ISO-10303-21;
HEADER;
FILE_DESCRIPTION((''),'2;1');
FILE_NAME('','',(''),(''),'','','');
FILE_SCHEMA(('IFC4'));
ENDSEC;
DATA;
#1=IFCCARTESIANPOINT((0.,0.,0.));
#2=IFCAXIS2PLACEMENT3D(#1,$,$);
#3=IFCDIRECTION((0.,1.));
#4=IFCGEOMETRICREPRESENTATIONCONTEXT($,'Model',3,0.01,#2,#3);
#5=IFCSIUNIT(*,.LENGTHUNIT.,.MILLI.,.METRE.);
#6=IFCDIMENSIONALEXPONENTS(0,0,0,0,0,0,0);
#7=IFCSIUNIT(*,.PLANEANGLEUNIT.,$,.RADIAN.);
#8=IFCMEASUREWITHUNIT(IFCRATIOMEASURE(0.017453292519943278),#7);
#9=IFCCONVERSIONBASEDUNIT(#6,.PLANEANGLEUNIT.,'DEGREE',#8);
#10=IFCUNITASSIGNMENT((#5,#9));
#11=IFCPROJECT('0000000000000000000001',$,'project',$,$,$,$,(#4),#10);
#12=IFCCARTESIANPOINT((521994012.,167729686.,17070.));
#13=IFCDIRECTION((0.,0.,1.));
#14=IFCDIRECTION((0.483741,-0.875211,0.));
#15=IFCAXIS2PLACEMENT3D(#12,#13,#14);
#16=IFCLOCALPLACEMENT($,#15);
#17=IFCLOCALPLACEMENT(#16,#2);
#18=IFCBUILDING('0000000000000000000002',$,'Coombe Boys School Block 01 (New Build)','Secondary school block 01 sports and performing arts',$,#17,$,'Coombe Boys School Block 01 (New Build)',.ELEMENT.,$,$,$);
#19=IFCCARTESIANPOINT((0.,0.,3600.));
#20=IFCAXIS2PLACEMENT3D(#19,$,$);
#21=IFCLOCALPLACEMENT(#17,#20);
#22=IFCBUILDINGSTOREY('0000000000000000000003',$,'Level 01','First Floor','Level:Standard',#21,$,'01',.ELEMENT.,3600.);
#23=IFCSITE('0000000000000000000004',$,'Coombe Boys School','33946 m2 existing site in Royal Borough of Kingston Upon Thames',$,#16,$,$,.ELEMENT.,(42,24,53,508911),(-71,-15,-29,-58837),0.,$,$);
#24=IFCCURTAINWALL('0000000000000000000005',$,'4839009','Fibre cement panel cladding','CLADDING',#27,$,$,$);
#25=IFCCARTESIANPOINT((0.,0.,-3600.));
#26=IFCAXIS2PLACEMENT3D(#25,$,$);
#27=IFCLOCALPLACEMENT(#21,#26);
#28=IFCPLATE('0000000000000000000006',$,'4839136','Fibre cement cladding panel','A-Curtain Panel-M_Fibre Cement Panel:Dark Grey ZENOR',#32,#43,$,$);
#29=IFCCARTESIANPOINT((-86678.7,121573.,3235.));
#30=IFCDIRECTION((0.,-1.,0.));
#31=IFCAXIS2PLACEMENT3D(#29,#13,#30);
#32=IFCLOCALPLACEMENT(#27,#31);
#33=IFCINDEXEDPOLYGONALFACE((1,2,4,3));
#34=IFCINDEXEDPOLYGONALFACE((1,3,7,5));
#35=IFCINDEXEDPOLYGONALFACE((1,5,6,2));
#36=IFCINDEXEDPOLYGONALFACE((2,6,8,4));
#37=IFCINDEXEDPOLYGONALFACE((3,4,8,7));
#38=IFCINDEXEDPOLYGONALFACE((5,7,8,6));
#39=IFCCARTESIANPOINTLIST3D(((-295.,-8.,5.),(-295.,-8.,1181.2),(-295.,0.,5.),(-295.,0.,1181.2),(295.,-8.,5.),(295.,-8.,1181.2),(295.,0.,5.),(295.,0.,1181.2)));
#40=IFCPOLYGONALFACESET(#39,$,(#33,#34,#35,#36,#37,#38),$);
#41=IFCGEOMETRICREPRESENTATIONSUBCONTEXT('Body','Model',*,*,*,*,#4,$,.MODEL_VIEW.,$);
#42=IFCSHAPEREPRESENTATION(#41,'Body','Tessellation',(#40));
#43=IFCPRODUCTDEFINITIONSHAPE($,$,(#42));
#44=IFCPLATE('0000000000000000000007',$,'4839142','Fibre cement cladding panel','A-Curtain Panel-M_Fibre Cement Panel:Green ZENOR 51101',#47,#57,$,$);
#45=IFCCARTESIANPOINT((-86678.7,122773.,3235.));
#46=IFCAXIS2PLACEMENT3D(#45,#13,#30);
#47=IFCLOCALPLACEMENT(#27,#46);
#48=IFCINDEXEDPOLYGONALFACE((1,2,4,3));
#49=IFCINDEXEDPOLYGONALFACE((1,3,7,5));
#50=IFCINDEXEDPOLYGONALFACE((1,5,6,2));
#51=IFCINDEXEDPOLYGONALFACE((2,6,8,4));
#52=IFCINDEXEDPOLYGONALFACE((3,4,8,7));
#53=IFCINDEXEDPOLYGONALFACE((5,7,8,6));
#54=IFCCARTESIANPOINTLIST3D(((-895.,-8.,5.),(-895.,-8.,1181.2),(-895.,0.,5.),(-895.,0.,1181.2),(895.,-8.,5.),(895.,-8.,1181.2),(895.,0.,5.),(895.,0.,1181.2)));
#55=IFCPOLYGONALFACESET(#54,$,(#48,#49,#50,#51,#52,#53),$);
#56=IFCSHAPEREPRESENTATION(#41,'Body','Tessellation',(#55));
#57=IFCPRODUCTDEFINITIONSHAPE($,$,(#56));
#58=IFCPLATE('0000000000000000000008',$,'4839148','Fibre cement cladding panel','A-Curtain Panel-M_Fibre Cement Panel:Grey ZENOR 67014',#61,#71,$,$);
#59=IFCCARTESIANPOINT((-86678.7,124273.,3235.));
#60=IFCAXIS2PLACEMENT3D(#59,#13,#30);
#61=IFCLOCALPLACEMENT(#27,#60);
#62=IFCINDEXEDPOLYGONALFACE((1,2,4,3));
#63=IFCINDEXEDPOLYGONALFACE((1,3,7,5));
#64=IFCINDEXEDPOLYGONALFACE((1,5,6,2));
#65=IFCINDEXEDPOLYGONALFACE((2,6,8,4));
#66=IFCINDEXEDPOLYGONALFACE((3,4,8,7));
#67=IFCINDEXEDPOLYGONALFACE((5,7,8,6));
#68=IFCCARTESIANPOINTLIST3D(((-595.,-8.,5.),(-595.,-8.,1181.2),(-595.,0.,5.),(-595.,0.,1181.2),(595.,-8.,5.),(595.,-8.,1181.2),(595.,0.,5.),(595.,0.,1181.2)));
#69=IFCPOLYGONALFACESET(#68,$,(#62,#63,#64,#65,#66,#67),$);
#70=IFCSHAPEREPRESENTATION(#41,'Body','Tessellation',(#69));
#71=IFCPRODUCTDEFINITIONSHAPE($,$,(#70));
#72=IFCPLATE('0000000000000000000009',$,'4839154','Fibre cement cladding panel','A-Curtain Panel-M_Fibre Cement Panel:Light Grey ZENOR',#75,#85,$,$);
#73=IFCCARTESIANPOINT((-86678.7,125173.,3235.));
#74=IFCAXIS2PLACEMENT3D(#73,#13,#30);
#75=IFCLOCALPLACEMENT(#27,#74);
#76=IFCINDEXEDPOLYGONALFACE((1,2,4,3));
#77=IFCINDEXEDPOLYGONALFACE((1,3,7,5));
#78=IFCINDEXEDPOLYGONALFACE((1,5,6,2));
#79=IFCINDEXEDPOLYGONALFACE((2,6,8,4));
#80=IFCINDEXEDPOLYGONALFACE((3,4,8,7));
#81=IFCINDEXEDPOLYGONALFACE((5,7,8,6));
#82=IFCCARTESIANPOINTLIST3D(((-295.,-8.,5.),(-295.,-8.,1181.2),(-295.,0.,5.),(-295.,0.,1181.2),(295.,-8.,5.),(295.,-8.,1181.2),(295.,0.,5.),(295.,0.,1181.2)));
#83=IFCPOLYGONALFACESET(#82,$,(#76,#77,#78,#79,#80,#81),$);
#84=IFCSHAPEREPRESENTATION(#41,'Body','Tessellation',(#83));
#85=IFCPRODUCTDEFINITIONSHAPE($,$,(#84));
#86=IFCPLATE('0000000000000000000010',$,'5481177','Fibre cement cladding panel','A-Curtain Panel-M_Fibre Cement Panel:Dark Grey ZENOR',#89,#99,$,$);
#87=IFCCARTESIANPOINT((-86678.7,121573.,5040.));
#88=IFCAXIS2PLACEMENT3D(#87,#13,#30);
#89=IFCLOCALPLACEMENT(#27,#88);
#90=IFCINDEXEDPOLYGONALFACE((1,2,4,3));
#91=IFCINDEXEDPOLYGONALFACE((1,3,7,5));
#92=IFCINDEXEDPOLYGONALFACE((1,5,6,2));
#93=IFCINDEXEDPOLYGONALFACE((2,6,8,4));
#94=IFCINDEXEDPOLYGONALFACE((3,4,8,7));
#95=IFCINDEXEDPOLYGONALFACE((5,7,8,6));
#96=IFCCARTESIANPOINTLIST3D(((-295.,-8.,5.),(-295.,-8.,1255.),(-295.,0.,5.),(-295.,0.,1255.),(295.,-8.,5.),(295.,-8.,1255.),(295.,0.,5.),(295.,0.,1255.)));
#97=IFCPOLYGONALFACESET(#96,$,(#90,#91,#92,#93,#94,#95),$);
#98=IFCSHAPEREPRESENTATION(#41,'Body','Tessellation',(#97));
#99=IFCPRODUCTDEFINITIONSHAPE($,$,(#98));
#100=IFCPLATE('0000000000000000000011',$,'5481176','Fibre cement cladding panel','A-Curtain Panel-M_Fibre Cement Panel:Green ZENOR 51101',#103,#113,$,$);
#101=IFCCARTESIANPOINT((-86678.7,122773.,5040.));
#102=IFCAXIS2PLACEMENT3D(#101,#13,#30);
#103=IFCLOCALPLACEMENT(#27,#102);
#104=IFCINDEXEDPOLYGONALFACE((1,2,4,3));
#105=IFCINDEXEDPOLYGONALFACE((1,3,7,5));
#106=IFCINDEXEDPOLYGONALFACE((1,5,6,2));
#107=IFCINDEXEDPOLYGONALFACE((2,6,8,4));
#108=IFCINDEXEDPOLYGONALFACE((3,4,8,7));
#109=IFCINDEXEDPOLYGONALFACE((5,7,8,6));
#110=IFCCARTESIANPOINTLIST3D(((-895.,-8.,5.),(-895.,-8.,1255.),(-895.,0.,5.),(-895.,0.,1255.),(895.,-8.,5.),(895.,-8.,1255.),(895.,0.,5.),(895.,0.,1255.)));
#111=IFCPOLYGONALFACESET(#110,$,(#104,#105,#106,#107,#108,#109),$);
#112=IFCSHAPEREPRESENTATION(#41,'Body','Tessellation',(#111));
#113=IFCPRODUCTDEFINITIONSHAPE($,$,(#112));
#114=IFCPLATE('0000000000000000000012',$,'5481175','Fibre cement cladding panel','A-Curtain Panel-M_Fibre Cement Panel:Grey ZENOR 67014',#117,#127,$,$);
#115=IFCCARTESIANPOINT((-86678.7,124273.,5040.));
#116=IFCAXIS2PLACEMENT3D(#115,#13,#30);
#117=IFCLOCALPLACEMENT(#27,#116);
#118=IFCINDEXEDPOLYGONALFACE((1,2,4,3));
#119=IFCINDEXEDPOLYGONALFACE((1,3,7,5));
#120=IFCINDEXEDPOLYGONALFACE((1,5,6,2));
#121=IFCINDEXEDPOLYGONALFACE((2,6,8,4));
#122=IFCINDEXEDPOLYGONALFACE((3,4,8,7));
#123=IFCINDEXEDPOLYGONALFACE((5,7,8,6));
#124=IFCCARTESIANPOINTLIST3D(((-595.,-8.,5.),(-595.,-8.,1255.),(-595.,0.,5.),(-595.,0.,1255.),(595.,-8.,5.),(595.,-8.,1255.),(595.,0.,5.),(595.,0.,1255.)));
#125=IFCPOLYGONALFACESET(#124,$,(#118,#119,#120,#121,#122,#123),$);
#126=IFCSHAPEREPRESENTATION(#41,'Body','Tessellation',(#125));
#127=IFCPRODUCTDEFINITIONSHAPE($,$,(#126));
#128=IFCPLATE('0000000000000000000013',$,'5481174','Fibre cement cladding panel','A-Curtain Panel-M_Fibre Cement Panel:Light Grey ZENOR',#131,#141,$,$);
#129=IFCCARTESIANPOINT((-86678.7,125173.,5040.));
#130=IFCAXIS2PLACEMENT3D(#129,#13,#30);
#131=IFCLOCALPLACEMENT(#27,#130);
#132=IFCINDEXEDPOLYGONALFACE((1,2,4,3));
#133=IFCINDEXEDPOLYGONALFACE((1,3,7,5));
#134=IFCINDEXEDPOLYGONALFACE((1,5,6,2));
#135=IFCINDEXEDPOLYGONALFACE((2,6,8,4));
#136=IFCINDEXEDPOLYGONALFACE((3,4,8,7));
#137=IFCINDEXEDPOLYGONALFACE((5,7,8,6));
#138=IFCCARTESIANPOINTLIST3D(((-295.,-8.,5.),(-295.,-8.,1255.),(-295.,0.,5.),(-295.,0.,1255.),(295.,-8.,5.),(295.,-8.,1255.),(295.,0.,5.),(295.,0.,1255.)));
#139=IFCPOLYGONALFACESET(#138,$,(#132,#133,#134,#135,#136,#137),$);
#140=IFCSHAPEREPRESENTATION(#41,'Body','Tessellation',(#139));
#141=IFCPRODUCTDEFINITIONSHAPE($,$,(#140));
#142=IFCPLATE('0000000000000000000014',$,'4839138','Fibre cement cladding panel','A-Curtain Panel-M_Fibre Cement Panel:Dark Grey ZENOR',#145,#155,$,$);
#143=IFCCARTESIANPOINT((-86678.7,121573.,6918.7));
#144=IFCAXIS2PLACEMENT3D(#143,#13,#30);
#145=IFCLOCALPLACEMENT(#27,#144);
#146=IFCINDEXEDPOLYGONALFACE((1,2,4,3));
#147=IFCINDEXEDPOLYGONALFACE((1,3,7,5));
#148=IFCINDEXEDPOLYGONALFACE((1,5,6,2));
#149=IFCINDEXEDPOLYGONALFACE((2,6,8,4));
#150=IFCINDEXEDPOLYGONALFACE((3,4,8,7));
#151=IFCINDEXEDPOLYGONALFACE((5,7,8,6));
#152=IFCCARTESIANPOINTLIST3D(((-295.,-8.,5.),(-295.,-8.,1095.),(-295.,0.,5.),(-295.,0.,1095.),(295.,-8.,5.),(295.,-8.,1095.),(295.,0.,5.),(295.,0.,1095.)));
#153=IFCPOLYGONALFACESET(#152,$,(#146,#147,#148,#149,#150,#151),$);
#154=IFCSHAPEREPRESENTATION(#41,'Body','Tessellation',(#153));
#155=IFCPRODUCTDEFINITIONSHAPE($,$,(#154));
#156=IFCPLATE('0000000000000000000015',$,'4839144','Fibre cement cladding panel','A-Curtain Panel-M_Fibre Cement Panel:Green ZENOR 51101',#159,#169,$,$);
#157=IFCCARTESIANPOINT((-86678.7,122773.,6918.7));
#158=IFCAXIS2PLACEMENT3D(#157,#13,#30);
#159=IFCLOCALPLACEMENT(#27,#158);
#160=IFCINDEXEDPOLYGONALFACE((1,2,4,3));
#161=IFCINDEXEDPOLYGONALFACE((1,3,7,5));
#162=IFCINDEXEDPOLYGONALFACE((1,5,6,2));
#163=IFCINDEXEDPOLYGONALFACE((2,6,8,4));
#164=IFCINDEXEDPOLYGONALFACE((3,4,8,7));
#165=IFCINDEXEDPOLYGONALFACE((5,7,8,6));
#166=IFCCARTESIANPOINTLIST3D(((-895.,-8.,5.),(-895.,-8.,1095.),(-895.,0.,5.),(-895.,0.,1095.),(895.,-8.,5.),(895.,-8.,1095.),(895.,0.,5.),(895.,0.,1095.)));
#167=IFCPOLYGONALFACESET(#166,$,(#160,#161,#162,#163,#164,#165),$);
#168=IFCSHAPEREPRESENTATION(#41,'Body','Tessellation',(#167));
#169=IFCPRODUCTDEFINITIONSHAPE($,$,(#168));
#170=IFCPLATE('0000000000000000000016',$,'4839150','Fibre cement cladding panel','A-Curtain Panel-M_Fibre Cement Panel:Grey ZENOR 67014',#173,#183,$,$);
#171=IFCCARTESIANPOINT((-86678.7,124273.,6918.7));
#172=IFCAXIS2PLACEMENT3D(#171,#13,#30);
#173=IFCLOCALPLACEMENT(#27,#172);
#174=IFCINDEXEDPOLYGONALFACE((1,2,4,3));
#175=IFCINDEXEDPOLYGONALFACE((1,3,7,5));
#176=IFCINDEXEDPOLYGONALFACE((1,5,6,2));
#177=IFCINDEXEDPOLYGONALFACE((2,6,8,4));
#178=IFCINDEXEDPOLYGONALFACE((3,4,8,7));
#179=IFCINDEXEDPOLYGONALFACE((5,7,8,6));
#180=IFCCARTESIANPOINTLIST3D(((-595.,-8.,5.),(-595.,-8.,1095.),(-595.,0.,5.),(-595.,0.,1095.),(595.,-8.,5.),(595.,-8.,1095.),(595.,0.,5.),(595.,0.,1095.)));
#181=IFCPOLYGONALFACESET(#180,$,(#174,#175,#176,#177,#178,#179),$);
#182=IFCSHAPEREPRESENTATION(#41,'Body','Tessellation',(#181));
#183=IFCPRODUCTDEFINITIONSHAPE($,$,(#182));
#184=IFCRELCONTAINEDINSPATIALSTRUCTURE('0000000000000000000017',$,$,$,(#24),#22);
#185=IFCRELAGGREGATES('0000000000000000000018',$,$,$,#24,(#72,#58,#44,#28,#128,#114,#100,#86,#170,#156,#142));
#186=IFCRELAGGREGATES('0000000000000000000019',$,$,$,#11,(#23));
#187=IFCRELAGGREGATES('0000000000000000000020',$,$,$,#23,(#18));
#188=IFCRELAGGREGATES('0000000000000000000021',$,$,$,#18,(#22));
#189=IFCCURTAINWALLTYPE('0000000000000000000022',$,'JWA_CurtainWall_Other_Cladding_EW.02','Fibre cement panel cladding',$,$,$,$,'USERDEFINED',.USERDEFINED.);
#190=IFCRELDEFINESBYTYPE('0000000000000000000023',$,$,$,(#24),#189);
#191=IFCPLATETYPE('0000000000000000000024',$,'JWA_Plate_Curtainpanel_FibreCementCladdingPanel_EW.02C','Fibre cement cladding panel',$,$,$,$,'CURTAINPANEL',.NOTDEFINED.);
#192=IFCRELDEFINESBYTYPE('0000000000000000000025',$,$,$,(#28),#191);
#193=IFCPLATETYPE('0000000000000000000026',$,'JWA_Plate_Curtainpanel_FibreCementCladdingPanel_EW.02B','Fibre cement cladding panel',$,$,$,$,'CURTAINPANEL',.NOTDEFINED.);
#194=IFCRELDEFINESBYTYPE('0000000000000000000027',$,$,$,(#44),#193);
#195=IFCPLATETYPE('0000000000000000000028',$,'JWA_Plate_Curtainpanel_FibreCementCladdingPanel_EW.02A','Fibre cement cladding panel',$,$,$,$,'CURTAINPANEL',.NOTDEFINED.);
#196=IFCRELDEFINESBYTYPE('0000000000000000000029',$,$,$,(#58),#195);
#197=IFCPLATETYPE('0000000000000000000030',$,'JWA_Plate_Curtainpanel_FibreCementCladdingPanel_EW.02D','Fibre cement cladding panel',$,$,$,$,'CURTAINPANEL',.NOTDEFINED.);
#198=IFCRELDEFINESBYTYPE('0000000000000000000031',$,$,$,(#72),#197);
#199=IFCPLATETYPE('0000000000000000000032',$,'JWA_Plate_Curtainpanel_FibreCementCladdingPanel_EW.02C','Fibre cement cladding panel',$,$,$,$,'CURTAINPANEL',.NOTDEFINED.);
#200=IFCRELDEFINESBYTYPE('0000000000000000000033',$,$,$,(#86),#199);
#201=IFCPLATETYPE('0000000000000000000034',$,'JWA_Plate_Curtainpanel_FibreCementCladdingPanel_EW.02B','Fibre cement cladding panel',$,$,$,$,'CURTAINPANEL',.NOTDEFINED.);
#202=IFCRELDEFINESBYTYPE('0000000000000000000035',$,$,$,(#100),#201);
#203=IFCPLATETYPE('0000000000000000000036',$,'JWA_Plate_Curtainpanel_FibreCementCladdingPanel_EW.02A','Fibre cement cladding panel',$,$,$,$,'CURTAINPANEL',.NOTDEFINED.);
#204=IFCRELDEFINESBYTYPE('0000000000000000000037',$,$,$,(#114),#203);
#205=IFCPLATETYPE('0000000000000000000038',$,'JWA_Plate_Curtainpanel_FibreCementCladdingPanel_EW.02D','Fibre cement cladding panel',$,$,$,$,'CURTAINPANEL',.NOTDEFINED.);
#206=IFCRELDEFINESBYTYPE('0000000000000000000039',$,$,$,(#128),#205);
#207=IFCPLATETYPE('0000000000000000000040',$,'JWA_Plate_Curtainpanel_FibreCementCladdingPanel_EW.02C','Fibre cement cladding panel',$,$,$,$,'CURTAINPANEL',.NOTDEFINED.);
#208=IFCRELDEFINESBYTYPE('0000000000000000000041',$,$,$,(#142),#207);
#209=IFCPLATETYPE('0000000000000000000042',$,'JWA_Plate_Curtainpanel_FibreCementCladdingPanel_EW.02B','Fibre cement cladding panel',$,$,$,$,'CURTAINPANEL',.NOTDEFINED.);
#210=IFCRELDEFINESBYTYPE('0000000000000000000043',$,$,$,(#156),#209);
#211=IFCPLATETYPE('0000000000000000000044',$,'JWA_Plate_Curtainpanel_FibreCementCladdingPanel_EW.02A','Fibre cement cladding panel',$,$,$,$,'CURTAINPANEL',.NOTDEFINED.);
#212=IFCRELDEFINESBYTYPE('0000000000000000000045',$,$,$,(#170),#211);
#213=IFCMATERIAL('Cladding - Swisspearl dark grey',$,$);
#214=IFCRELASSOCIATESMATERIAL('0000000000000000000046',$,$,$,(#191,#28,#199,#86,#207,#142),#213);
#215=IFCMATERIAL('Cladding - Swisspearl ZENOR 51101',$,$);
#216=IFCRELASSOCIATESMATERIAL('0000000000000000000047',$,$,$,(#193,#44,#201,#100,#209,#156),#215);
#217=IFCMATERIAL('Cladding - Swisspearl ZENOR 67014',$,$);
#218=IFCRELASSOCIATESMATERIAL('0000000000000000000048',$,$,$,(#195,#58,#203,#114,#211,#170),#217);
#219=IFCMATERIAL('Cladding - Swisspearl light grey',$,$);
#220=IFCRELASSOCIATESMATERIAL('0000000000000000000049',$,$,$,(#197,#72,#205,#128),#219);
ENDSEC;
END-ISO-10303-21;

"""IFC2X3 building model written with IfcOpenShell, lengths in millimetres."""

from ifc_helpers import new_model, entity, si_unit, converted_unit, direction, frame, origin, origin_2d_with_axis, place, context, subcontext, project, spatial, rectangle, extrude, source, transform, mapped, material, type_object, type_shapes, element, aggregate, save


model = new_model("IFC2X3")

# Units and contexts
model_context = context("Model", 3, precision=0.01, world=origin(), true_north=direction((0.0, 1.0)))
body_context = subcontext(model_context, "Body", "Model", "MODEL_VIEW")
ifc_project = project(units=[si_unit("LENGTHUNIT", "METRE", prefix="MILLI"), converted_unit("PLANEANGLEUNIT", "DEGREE", entity("IfcRatioMeasure", 0.017453292519943278), si_unit("PLANEANGLEUNIT", "RADIAN"), dimensions=[0, 0, 0, 0, 0, 0, 0])], contexts=[model_context])

# Site, building, storey
site_placement = place(None, frame((521994012.0, 167729686.0, 17070.0), z_axis=(0.0, 0.0, 1.0), x_axis=(0.483741, -0.875211, 0.0)))
site = spatial("IfcSite", under=ifc_project, at=site_placement, Name="Coombe Boys School", Description="33946 m2 existing site in Royal Borough of Kingston Upon Thames", CompositionType="ELEMENT", RefLatitude=(42, 24, 53, 508911), RefLongitude=(-71, -15, -29, -58837), RefElevation=0.0)
building_placement = place(site_placement, origin())
building = spatial("IfcBuilding", under=site, at=building_placement, Name="Coombe Boys School Block 01 (New Build)", Description="Secondary school block 01 sports and performing arts", LongName="Coombe Boys School Block 01 (New Build)", CompositionType="ELEMENT")
storey_placement = place(building_placement, frame((0.0, 0.0, 3600.0)))
storey = spatial("IfcBuildingStorey", under=building, at=storey_placement, Name="Level 01", Description="First Floor", ObjectType="Level:Standard", LongName="01", CompositionType="ELEMENT", Elevation=3600.0)

# Curtain wall, plates
curtain_wall_type = type_object("IfcCurtainWallType", Name="JWA_CurtainWall_Other_Cladding_EW.02", Description="Fibre cement panel cladding", ElementType="USERDEFINED", PredefinedType="USERDEFINED")
curtain_wall_placement = place(storey_placement, frame((0.0, 0.0, -3600.0)))
curtain_wall = element("IfcCurtainWall", 1, at=curtain_wall_placement, inside=storey, type_object=curtain_wall_type, Name="4839009", Description="Fibre cement panel cladding", ObjectType="CLADDING")
ifc_material_1 = material(Name="Cladding - Swisspearl dark grey")
plate_type_1 = type_object("IfcPlateType", Name="JWA_Plate_Curtainpanel_FibreCementCladdingPanel_EW.02C", Description="Fibre cement cladding panel", ElementType="CURTAINPANEL", PredefinedType="NOTDEFINED", material=ifc_material_1)
shared_shape_1 = source(origin(), body_context, "Body", "SweptSolid", [
    extrude(rectangle(XDim=590.0, YDim=8.0, at=origin_2d_with_axis()), frame((0.0, -4.0, 5.0), z_axis=(0.0, 0.0, 1.0), x_axis=(-1.0, 0.0, 0.0)), (0.0, 0.0, 1.0), 1176.2),
])
type_shapes(plate_type_1, [shared_shape_1])
plate_1_placement = place(curtain_wall_placement, frame((-86678.7, 121573.0, 3235.0), z_axis=(0.0, 0.0, 1.0), x_axis=(0.0, -1.0, 0.0)))
plate_1 = element("IfcPlate", 2, at=plate_1_placement, type_object=plate_type_1, material=ifc_material_1, Name="4839136", Description="Fibre cement cladding panel", ObjectType="A-Curtain Panel-M_Fibre Cement Panel:Dark Grey ZENOR", context=body_context, shape_type="MappedRepresentation", body=[
    mapped(shared_shape_1, transform((0.0, 0.0, 0.0), scale=1.0)),
])
ifc_material_2 = material(Name="Cladding - Swisspearl ZENOR 51101")
plate_type_2 = type_object("IfcPlateType", Name="JWA_Plate_Curtainpanel_FibreCementCladdingPanel_EW.02B", Description="Fibre cement cladding panel", ElementType="CURTAINPANEL", PredefinedType="NOTDEFINED", material=ifc_material_2)
shared_shape_2 = source(origin(), body_context, "Body", "SweptSolid", [
    extrude(rectangle(XDim=1790.0, YDim=8.0, at=origin_2d_with_axis()), frame((0.0, -4.0, 5.0), z_axis=(0.0, 0.0, 1.0), x_axis=(-1.0, 0.0, 0.0)), (0.0, 0.0, 1.0), 1176.2),
])
type_shapes(plate_type_2, [shared_shape_2])
plate_2_placement = place(curtain_wall_placement, frame((-86678.7, 122773.0, 3235.0), z_axis=(0.0, 0.0, 1.0), x_axis=(0.0, -1.0, 0.0)))
plate_2 = element("IfcPlate", 3, at=plate_2_placement, type_object=plate_type_2, material=ifc_material_2, Name="4839142", Description="Fibre cement cladding panel", ObjectType="A-Curtain Panel-M_Fibre Cement Panel:Green ZENOR 51101", context=body_context, shape_type="MappedRepresentation", body=[
    mapped(shared_shape_2, transform((0.0, 0.0, 0.0), scale=1.0)),
])
ifc_material_3 = material(Name="Cladding - Swisspearl ZENOR 67014")
plate_type_3 = type_object("IfcPlateType", Name="JWA_Plate_Curtainpanel_FibreCementCladdingPanel_EW.02A", Description="Fibre cement cladding panel", ElementType="CURTAINPANEL", PredefinedType="NOTDEFINED", material=ifc_material_3)
shared_shape_3 = source(origin(), body_context, "Body", "SweptSolid", [
    extrude(rectangle(XDim=1190.0, YDim=8.0, at=origin_2d_with_axis()), frame((0.0, -4.0, 5.0), z_axis=(0.0, 0.0, 1.0), x_axis=(-1.0, 0.0, 0.0)), (0.0, 0.0, 1.0), 1176.2),
])
type_shapes(plate_type_3, [shared_shape_3])
plate_3_placement = place(curtain_wall_placement, frame((-86678.7, 124273.0, 3235.0), z_axis=(0.0, 0.0, 1.0), x_axis=(0.0, -1.0, 0.0)))
plate_3 = element("IfcPlate", 4, at=plate_3_placement, type_object=plate_type_3, material=ifc_material_3, Name="4839148", Description="Fibre cement cladding panel", ObjectType="A-Curtain Panel-M_Fibre Cement Panel:Grey ZENOR 67014", context=body_context, shape_type="MappedRepresentation", body=[
    mapped(shared_shape_3, transform((0.0, 0.0, 0.0), scale=1.0)),
])
ifc_material_4 = material(Name="Cladding - Swisspearl light grey")
plate_type_4 = type_object("IfcPlateType", Name="JWA_Plate_Curtainpanel_FibreCementCladdingPanel_EW.02D", Description="Fibre cement cladding panel", ElementType="CURTAINPANEL", PredefinedType="NOTDEFINED", material=ifc_material_4)
shared_shape_4 = source(origin(), body_context, "Body", "SweptSolid", [
    extrude(rectangle(XDim=590.0, YDim=8.0, at=origin_2d_with_axis()), frame((0.0, -4.0, 5.0), z_axis=(0.0, 0.0, 1.0), x_axis=(-1.0, 0.0, 0.0)), (0.0, 0.0, 1.0), 1176.2),
])
type_shapes(plate_type_4, [shared_shape_4])
plate_4_placement = place(curtain_wall_placement, frame((-86678.7, 125173.0, 3235.0), z_axis=(0.0, 0.0, 1.0), x_axis=(0.0, -1.0, 0.0)))
plate_4 = element("IfcPlate", 5, at=plate_4_placement, type_object=plate_type_4, material=ifc_material_4, Name="4839154", Description="Fibre cement cladding panel", ObjectType="A-Curtain Panel-M_Fibre Cement Panel:Light Grey ZENOR", context=body_context, shape_type="MappedRepresentation", body=[
    mapped(shared_shape_4, transform((0.0, 0.0, 0.0), scale=1.0)),
])
plate_type_5 = type_object("IfcPlateType", Name="JWA_Plate_Curtainpanel_FibreCementCladdingPanel_EW.02C", Description="Fibre cement cladding panel", ElementType="CURTAINPANEL", PredefinedType="NOTDEFINED", material=ifc_material_1)
shared_shape_5 = source(origin(), body_context, "Body", "SweptSolid", [
    extrude(rectangle(XDim=590.0, YDim=8.0, at=origin_2d_with_axis()), frame((0.0, -4.0, 5.0), z_axis=(0.0, 0.0, 1.0), x_axis=(-1.0, 0.0, 0.0)), (0.0, 0.0, 1.0), 1250.0),
])
type_shapes(plate_type_5, [shared_shape_5])
plate_5_placement = place(curtain_wall_placement, frame((-86678.7, 121573.0, 5040.0), z_axis=(0.0, 0.0, 1.0), x_axis=(0.0, -1.0, 0.0)))
plate_5 = element("IfcPlate", 6, at=plate_5_placement, type_object=plate_type_5, material=ifc_material_1, Name="5481177", Description="Fibre cement cladding panel", ObjectType="A-Curtain Panel-M_Fibre Cement Panel:Dark Grey ZENOR", context=body_context, shape_type="MappedRepresentation", body=[
    mapped(shared_shape_5, transform((0.0, 0.0, 0.0), scale=1.0)),
])
plate_type_6 = type_object("IfcPlateType", Name="JWA_Plate_Curtainpanel_FibreCementCladdingPanel_EW.02B", Description="Fibre cement cladding panel", ElementType="CURTAINPANEL", PredefinedType="NOTDEFINED", material=ifc_material_2)
shared_shape_6 = source(origin(), body_context, "Body", "SweptSolid", [
    extrude(rectangle(XDim=1790.0, YDim=8.0, at=origin_2d_with_axis()), frame((0.0, -4.0, 5.0), z_axis=(0.0, 0.0, 1.0), x_axis=(-1.0, 0.0, 0.0)), (0.0, 0.0, 1.0), 1250.0),
])
type_shapes(plate_type_6, [shared_shape_6])
plate_6_placement = place(curtain_wall_placement, frame((-86678.7, 122773.0, 5040.0), z_axis=(0.0, 0.0, 1.0), x_axis=(0.0, -1.0, 0.0)))
plate_6 = element("IfcPlate", 7, at=plate_6_placement, type_object=plate_type_6, material=ifc_material_2, Name="5481176", Description="Fibre cement cladding panel", ObjectType="A-Curtain Panel-M_Fibre Cement Panel:Green ZENOR 51101", context=body_context, shape_type="MappedRepresentation", body=[
    mapped(shared_shape_6, transform((0.0, 0.0, 0.0), scale=1.0)),
])
plate_type_7 = type_object("IfcPlateType", Name="JWA_Plate_Curtainpanel_FibreCementCladdingPanel_EW.02A", Description="Fibre cement cladding panel", ElementType="CURTAINPANEL", PredefinedType="NOTDEFINED", material=ifc_material_3)
shared_shape_7 = source(origin(), body_context, "Body", "SweptSolid", [
    extrude(rectangle(XDim=1190.0, YDim=8.0, at=origin_2d_with_axis()), frame((0.0, -4.0, 5.0), z_axis=(0.0, 0.0, 1.0), x_axis=(-1.0, 0.0, 0.0)), (0.0, 0.0, 1.0), 1250.0),
])
type_shapes(plate_type_7, [shared_shape_7])
plate_7_placement = place(curtain_wall_placement, frame((-86678.7, 124273.0, 5040.0), z_axis=(0.0, 0.0, 1.0), x_axis=(0.0, -1.0, 0.0)))
plate_7 = element("IfcPlate", 8, at=plate_7_placement, type_object=plate_type_7, material=ifc_material_3, Name="5481175", Description="Fibre cement cladding panel", ObjectType="A-Curtain Panel-M_Fibre Cement Panel:Grey ZENOR 67014", context=body_context, shape_type="MappedRepresentation", body=[
    mapped(shared_shape_7, transform((0.0, 0.0, 0.0), scale=1.0)),
])
plate_type_8 = type_object("IfcPlateType", Name="JWA_Plate_Curtainpanel_FibreCementCladdingPanel_EW.02D", Description="Fibre cement cladding panel", ElementType="CURTAINPANEL", PredefinedType="NOTDEFINED", material=ifc_material_4)
shared_shape_8 = source(origin(), body_context, "Body", "SweptSolid", [
    extrude(rectangle(XDim=590.0, YDim=8.0, at=origin_2d_with_axis()), frame((0.0, -4.0, 5.0), z_axis=(0.0, 0.0, 1.0), x_axis=(-1.0, 0.0, 0.0)), (0.0, 0.0, 1.0), 1250.0),
])
type_shapes(plate_type_8, [shared_shape_8])
plate_8_placement = place(curtain_wall_placement, frame((-86678.7, 125173.0, 5040.0), z_axis=(0.0, 0.0, 1.0), x_axis=(0.0, -1.0, 0.0)))
plate_8 = element("IfcPlate", 9, at=plate_8_placement, type_object=plate_type_8, material=ifc_material_4, Name="5481174", Description="Fibre cement cladding panel", ObjectType="A-Curtain Panel-M_Fibre Cement Panel:Light Grey ZENOR", context=body_context, shape_type="MappedRepresentation", body=[
    mapped(shared_shape_8, transform((0.0, 0.0, 0.0), scale=1.0)),
])
plate_type_9 = type_object("IfcPlateType", Name="JWA_Plate_Curtainpanel_FibreCementCladdingPanel_EW.02C", Description="Fibre cement cladding panel", ElementType="CURTAINPANEL", PredefinedType="NOTDEFINED", material=ifc_material_1)
shared_shape_9 = source(origin(), body_context, "Body", "SweptSolid", [
    extrude(rectangle(XDim=590.0, YDim=8.0, at=origin_2d_with_axis()), frame((0.0, -4.0, 5.0), z_axis=(0.0, 0.0, 1.0), x_axis=(-1.0, 0.0, 0.0)), (0.0, 0.0, 1.0), 1090.0),
])
type_shapes(plate_type_9, [shared_shape_9])
plate_9_placement = place(curtain_wall_placement, frame((-86678.7, 121573.0, 6918.7), z_axis=(0.0, 0.0, 1.0), x_axis=(0.0, -1.0, 0.0)))
plate_9 = element("IfcPlate", 10, at=plate_9_placement, type_object=plate_type_9, material=ifc_material_1, Name="4839138", Description="Fibre cement cladding panel", ObjectType="A-Curtain Panel-M_Fibre Cement Panel:Dark Grey ZENOR", context=body_context, shape_type="MappedRepresentation", body=[
    mapped(shared_shape_9, transform((0.0, 0.0, 0.0), scale=1.0)),
])
plate_type_10 = type_object("IfcPlateType", Name="JWA_Plate_Curtainpanel_FibreCementCladdingPanel_EW.02B", Description="Fibre cement cladding panel", ElementType="CURTAINPANEL", PredefinedType="NOTDEFINED", material=ifc_material_2)
shared_shape_10 = source(origin(), body_context, "Body", "SweptSolid", [
    extrude(rectangle(XDim=1790.0, YDim=8.0, at=origin_2d_with_axis()), frame((0.0, -4.0, 5.0), z_axis=(0.0, 0.0, 1.0), x_axis=(-1.0, 0.0, 0.0)), (0.0, 0.0, 1.0), 1090.0),
])
type_shapes(plate_type_10, [shared_shape_10])
plate_10_placement = place(curtain_wall_placement, frame((-86678.7, 122773.0, 6918.7), z_axis=(0.0, 0.0, 1.0), x_axis=(0.0, -1.0, 0.0)))
plate_10 = element("IfcPlate", 11, at=plate_10_placement, type_object=plate_type_10, material=ifc_material_2, Name="4839144", Description="Fibre cement cladding panel", ObjectType="A-Curtain Panel-M_Fibre Cement Panel:Green ZENOR 51101", context=body_context, shape_type="MappedRepresentation", body=[
    mapped(shared_shape_10, transform((0.0, 0.0, 0.0), scale=1.0)),
])
plate_type_11 = type_object("IfcPlateType", Name="JWA_Plate_Curtainpanel_FibreCementCladdingPanel_EW.02A", Description="Fibre cement cladding panel", ElementType="CURTAINPANEL", PredefinedType="NOTDEFINED", material=ifc_material_3)
shared_shape_11 = source(origin(), body_context, "Body", "SweptSolid", [
    extrude(rectangle(XDim=1190.0, YDim=8.0, at=origin_2d_with_axis()), frame((0.0, -4.0, 5.0), z_axis=(0.0, 0.0, 1.0), x_axis=(-1.0, 0.0, 0.0)), (0.0, 0.0, 1.0), 1090.0),
])
type_shapes(plate_type_11, [shared_shape_11])
plate_11_placement = place(curtain_wall_placement, frame((-86678.7, 124273.0, 6918.7), z_axis=(0.0, 0.0, 1.0), x_axis=(0.0, -1.0, 0.0)))
plate_11 = element("IfcPlate", 12, at=plate_11_placement, type_object=plate_type_11, material=ifc_material_3, Name="4839150", Description="Fibre cement cladding panel", ObjectType="A-Curtain Panel-M_Fibre Cement Panel:Grey ZENOR 67014", context=body_context, shape_type="MappedRepresentation", body=[
    mapped(shared_shape_11, transform((0.0, 0.0, 0.0), scale=1.0)),
])
aggregate(curtain_wall, [plate_4, plate_3, plate_2, plate_1, plate_8, plate_7, plate_6, plate_5, plate_11, plate_10, plate_9])

save(model, "model.ifc")
